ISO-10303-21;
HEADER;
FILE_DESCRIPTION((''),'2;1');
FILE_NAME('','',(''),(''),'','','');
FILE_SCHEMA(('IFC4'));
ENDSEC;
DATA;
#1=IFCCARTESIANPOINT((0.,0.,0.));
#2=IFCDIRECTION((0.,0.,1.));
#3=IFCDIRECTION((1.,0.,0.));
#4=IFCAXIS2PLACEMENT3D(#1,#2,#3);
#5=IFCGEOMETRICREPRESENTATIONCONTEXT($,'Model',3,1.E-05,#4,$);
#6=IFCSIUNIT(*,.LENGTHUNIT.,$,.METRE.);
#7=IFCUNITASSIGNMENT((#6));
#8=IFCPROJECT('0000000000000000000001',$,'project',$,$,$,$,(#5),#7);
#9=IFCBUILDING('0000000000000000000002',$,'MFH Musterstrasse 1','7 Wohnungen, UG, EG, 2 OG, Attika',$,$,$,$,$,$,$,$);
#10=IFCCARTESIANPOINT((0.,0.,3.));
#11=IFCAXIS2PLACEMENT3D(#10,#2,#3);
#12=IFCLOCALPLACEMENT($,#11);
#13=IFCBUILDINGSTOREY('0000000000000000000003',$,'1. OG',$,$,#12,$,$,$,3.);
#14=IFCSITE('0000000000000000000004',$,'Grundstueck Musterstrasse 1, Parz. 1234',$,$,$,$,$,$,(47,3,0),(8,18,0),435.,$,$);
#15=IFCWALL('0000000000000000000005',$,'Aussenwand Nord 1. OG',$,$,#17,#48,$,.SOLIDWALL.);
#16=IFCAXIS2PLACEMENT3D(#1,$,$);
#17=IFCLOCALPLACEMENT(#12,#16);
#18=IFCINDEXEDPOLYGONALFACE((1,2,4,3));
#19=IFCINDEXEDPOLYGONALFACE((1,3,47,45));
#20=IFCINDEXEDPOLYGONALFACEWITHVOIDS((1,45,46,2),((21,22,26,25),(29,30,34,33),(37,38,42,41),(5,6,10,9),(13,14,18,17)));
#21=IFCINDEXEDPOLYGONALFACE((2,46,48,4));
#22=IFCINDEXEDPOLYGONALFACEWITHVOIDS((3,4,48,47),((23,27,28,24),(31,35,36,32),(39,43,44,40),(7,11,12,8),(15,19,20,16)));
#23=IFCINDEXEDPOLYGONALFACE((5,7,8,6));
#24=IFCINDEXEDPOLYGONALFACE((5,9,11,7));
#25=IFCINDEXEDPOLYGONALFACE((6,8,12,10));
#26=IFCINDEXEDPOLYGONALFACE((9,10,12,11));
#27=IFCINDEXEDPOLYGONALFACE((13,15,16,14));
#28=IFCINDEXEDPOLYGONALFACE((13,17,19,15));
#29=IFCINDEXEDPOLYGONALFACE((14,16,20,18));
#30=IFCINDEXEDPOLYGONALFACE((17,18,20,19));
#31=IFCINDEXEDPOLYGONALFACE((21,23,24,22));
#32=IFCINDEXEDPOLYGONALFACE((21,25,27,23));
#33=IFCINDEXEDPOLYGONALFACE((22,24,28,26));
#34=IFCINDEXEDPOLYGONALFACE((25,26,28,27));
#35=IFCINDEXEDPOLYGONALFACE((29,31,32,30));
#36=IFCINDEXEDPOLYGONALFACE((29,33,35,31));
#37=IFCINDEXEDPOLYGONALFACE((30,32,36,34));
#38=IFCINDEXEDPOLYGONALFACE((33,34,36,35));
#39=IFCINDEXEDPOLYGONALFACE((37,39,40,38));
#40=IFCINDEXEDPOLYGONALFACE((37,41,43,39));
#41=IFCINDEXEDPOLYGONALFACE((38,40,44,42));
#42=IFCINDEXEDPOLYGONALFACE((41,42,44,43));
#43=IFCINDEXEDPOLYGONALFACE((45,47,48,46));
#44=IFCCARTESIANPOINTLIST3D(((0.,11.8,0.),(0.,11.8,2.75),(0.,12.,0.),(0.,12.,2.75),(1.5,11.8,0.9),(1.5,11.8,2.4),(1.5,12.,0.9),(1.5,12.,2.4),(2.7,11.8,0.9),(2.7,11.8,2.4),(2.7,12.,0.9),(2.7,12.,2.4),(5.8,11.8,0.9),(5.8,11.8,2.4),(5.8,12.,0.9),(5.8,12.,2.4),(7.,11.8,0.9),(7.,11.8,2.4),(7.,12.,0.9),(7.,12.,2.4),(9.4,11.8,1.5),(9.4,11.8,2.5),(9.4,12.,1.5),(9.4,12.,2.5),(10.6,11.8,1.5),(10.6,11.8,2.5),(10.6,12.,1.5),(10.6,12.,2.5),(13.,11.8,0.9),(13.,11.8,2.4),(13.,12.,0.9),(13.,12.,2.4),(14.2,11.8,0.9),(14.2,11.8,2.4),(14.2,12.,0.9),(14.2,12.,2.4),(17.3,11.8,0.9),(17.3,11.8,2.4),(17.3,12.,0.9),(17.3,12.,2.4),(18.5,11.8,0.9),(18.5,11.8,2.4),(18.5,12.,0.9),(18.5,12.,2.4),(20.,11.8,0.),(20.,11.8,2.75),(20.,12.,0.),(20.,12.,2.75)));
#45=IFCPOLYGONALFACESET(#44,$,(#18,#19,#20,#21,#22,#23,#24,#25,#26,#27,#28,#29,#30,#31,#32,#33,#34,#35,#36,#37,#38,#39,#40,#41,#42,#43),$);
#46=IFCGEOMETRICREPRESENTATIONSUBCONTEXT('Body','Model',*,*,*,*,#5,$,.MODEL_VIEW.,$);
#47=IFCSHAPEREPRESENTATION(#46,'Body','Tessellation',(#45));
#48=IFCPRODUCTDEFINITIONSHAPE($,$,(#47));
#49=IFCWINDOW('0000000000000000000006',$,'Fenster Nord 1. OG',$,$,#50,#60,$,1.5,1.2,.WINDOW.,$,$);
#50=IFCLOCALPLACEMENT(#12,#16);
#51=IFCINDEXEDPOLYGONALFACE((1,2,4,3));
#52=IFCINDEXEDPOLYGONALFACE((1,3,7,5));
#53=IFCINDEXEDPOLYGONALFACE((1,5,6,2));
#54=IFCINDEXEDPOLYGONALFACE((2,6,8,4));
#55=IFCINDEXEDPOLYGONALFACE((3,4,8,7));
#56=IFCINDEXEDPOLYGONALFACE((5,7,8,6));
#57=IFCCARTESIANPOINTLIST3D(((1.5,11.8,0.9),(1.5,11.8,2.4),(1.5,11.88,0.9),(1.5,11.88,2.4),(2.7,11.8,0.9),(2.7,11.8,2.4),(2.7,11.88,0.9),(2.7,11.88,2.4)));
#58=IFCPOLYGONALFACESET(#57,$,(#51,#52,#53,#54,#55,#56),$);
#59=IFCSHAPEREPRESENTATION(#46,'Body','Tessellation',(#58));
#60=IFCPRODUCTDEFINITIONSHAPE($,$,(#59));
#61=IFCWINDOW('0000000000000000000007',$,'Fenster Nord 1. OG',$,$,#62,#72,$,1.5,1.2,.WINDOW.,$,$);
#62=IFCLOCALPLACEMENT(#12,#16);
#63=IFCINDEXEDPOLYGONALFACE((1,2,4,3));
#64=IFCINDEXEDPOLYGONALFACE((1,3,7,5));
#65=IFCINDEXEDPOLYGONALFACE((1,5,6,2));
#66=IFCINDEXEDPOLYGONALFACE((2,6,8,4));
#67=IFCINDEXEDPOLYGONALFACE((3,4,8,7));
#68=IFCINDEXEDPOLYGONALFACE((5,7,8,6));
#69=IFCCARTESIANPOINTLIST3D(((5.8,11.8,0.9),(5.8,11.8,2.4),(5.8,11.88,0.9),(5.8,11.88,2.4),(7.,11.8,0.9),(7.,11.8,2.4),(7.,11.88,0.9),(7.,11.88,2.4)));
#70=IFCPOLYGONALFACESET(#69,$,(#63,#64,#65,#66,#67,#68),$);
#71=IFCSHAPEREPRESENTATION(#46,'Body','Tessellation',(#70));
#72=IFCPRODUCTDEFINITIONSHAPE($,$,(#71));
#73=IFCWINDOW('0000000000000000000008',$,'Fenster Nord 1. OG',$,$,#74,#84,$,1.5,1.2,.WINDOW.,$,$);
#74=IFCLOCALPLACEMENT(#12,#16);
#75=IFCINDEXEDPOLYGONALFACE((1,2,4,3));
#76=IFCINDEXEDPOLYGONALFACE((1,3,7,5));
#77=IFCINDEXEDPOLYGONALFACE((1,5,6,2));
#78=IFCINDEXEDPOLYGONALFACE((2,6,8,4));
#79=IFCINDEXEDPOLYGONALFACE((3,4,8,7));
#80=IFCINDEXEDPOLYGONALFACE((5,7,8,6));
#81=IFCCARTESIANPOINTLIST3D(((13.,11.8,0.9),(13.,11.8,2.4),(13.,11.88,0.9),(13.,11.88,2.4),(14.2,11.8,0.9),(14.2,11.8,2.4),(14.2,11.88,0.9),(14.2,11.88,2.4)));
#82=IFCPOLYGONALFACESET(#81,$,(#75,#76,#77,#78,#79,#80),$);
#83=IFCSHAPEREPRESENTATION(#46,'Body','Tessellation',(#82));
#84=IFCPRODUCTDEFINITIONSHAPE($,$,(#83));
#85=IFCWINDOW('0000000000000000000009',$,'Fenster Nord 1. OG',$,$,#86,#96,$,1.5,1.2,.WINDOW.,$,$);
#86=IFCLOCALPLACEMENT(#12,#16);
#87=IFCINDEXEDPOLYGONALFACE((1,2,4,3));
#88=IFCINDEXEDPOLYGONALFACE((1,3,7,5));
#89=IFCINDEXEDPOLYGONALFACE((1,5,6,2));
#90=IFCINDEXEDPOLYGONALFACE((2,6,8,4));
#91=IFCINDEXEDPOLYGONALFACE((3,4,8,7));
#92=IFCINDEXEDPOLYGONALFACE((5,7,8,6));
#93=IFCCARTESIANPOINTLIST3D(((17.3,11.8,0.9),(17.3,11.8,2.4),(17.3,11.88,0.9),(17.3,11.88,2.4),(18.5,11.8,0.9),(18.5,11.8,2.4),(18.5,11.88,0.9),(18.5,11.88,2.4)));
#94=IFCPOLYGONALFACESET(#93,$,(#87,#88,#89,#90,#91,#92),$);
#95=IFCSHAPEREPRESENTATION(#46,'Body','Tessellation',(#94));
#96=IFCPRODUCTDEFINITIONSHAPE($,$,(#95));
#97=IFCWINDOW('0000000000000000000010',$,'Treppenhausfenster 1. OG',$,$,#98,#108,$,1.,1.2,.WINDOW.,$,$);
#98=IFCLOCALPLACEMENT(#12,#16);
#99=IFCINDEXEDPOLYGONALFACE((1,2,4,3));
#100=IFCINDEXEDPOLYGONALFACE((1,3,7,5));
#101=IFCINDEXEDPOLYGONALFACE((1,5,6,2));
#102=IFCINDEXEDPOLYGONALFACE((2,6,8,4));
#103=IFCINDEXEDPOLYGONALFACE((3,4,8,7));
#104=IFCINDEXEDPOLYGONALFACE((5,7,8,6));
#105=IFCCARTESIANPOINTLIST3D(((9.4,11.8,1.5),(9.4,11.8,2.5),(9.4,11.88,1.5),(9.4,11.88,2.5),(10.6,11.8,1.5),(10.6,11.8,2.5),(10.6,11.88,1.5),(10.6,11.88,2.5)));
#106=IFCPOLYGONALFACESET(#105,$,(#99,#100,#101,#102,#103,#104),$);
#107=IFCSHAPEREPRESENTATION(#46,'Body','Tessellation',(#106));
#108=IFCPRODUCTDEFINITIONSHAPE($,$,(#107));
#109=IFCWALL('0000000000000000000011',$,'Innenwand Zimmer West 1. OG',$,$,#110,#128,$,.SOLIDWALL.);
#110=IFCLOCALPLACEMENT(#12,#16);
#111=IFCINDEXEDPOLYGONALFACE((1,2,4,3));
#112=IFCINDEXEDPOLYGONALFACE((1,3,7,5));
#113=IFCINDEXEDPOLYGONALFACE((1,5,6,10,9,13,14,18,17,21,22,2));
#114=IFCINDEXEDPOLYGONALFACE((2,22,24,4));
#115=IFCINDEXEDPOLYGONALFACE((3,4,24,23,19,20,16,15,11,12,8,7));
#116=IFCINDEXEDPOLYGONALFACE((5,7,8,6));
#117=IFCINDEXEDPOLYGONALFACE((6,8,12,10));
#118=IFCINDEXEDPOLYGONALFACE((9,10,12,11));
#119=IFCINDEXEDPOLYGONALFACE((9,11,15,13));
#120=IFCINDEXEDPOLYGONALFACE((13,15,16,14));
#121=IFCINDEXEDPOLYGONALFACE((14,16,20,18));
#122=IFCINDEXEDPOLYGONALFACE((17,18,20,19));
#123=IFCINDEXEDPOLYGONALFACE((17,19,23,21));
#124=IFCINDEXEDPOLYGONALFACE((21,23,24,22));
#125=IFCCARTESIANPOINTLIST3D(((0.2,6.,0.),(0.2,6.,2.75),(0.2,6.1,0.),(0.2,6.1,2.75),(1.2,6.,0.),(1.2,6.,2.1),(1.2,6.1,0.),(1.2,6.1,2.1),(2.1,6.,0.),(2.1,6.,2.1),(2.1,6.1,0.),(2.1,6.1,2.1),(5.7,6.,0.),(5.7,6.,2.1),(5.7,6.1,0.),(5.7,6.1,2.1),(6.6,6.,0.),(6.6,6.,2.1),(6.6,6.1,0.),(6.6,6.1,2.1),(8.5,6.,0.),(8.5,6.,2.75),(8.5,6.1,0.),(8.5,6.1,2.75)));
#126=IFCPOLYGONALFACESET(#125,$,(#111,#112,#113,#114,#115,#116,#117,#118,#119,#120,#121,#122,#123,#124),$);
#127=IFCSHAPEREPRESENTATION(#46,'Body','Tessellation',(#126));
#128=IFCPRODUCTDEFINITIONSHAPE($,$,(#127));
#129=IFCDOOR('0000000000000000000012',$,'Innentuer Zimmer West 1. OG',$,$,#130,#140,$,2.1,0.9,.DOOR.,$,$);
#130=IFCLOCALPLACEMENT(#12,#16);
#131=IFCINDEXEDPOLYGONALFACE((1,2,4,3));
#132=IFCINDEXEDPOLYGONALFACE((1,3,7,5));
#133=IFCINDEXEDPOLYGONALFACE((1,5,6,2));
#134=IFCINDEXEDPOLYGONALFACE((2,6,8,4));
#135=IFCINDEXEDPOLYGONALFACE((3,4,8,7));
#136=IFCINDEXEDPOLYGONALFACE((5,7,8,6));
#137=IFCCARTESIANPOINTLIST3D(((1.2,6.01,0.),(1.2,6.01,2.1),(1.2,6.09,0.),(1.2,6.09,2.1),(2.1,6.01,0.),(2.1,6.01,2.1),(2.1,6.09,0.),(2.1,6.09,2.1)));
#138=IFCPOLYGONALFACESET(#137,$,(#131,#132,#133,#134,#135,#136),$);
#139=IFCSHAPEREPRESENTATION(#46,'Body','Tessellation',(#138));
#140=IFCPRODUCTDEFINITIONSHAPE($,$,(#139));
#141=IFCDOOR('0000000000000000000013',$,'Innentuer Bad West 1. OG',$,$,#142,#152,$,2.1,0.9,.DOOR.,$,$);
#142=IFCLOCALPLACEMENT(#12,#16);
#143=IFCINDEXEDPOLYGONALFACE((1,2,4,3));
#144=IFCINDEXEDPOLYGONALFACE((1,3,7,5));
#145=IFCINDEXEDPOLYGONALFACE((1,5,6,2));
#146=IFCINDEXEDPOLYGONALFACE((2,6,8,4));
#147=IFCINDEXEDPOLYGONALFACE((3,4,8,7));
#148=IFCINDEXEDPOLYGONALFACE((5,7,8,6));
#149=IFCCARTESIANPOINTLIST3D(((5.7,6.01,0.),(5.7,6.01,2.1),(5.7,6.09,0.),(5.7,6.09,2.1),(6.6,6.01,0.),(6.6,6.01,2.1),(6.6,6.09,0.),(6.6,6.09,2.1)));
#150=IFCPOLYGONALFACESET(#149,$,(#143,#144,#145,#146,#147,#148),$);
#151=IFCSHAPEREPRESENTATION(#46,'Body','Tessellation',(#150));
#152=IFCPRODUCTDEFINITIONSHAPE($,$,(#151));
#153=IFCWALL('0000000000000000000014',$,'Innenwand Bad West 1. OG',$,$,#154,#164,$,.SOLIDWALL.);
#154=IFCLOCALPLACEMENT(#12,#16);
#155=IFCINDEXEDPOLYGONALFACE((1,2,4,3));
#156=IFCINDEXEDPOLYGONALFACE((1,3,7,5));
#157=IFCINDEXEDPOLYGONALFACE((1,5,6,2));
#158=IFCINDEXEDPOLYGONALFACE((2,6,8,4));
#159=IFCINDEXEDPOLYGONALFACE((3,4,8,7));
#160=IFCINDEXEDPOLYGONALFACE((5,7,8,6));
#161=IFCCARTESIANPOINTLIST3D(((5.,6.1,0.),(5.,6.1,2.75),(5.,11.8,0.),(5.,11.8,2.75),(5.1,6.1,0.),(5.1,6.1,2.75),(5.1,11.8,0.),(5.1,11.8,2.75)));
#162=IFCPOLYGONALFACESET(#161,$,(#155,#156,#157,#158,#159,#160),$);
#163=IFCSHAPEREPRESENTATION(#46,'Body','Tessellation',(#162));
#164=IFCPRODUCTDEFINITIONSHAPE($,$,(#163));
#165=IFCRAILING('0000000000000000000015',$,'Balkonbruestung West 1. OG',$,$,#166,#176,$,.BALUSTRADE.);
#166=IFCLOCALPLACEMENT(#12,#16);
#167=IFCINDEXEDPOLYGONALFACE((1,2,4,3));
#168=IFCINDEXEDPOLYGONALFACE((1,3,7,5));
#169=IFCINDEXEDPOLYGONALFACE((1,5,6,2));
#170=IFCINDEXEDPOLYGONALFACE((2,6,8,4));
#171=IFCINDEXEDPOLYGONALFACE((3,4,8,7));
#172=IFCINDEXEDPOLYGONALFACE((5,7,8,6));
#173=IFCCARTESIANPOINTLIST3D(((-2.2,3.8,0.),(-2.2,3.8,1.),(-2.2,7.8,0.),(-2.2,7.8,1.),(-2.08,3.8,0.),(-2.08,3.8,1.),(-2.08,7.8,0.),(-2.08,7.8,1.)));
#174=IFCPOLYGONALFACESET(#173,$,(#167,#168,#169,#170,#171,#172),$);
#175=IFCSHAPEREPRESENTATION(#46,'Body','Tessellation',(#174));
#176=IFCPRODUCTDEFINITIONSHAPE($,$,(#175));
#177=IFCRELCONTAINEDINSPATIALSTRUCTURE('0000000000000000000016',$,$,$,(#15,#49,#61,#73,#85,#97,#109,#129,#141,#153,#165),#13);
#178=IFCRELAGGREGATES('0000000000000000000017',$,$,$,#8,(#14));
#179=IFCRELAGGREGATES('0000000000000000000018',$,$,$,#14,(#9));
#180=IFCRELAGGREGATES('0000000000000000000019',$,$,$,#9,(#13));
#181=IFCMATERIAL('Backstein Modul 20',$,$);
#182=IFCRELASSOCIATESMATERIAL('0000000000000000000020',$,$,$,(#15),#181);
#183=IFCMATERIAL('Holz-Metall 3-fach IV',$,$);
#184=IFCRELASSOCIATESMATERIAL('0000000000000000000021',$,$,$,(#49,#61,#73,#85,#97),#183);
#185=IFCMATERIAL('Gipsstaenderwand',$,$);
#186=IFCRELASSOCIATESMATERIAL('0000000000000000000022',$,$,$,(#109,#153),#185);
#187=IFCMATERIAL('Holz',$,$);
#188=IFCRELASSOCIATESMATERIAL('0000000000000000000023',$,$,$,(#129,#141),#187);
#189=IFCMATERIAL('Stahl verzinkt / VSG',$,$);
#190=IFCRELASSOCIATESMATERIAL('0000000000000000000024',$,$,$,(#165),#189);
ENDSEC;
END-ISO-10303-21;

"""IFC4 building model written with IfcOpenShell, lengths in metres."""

from ifc_helpers import new_model, si_unit, frame, frame_2d, origin_with_axes, place, context, subcontext, project, spatial, rectangle, extrude, material, element, fill, save


model = new_model("IFC4")

# Units and contexts
model_context = context("Model", 3, precision=1e-05, world=origin_with_axes())
body_context = subcontext(model_context, "Body", "Model", "MODEL_VIEW")
ifc_project = project(units=[si_unit("LENGTHUNIT", "METRE")], contexts=[model_context])

# Site, building, storey
site = spatial("IfcSite", under=ifc_project, Name="Grundstueck Musterstrasse 1, Parz. 1234", RefLatitude=(47, 3, 0), RefLongitude=(8, 18, 0), RefElevation=435.0)
building = spatial("IfcBuilding", under=site, Name="MFH Musterstrasse 1", Description="7 Wohnungen, UG, EG, 2 OG, Attika")
storey_placement = place(None, frame((0.0, 0.0, 3.0), z_axis=(0.0, 0.0, 1.0), x_axis=(1.0, 0.0, 0.0)))
storey = spatial("IfcBuildingStorey", under=building, at=storey_placement, Name="1. OG", Elevation=3.0)

# Wall, openings, windows
ifc_material_1 = material(Name="Backstein Modul 20")
wall_1_placement = place(storey_placement, frame((0.0, 11.8, 0.0), z_axis=(0.0, 0.0, 1.0), x_axis=(1.0, 0.0, 0.0)))
wall_1 = element("IfcWall", 1, at=wall_1_placement, inside=storey, material=ifc_material_1, Name="Aussenwand Nord 1. OG", PredefinedType="SOLIDWALL", context=body_context, shape_type="SweptSolid", body=[
    extrude(rectangle(XDim=20.0, YDim=0.2, at=frame_2d((10.0, 0.1))), origin_with_axes(), (0.0, 0.0, 1.0), 2.75),
])
opening_1_placement = place(wall_1_placement, frame((1.5, -0.01, 0.9), z_axis=(0.0, 0.0, 1.0), x_axis=(1.0, 0.0, 0.0)))
opening_1 = element("IfcOpeningElement", 2, at=opening_1_placement, cuts=wall_1, context=body_context, shape_type="SweptSolid", body=[
    extrude(rectangle(XDim=1.2, YDim=0.42, at=frame_2d((0.6, 0.21))), origin_with_axes(), (0.0, 0.0, 1.0), 1.5),
])
opening_2_placement = place(wall_1_placement, frame((5.8, -0.01, 0.9), z_axis=(0.0, 0.0, 1.0), x_axis=(1.0, 0.0, 0.0)))
opening_2 = element("IfcOpeningElement", 3, at=opening_2_placement, cuts=wall_1, context=body_context, shape_type="SweptSolid", body=[
    extrude(rectangle(XDim=1.2, YDim=0.42, at=frame_2d((0.6, 0.21))), origin_with_axes(), (0.0, 0.0, 1.0), 1.5),
])
opening_3_placement = place(wall_1_placement, frame((13.0, -0.01, 0.9), z_axis=(0.0, 0.0, 1.0), x_axis=(1.0, 0.0, 0.0)))
opening_3 = element("IfcOpeningElement", 4, at=opening_3_placement, cuts=wall_1, context=body_context, shape_type="SweptSolid", body=[
    extrude(rectangle(XDim=1.2, YDim=0.42, at=frame_2d((0.6, 0.21))), origin_with_axes(), (0.0, 0.0, 1.0), 1.5),
])
opening_4_placement = place(wall_1_placement, frame((17.3, -0.01, 0.9), z_axis=(0.0, 0.0, 1.0), x_axis=(1.0, 0.0, 0.0)))
opening_4 = element("IfcOpeningElement", 5, at=opening_4_placement, cuts=wall_1, context=body_context, shape_type="SweptSolid", body=[
    extrude(rectangle(XDim=1.2, YDim=0.42, at=frame_2d((0.6, 0.21))), origin_with_axes(), (0.0, 0.0, 1.0), 1.5),
])
opening_5_placement = place(wall_1_placement, frame((9.4, -0.01, 1.5), z_axis=(0.0, 0.0, 1.0), x_axis=(1.0, 0.0, 0.0)))
opening_5 = element("IfcOpeningElement", 6, at=opening_5_placement, cuts=wall_1, context=body_context, shape_type="SweptSolid", body=[
    extrude(rectangle(XDim=1.2, YDim=0.42, at=frame_2d((0.6, 0.21))), origin_with_axes(), (0.0, 0.0, 1.0), 1.0),
])
ifc_material_2 = material(Name="Holz-Metall 3-fach IV")
window_1_placement = place(storey_placement, frame((1.5, 11.8, 0.9), z_axis=(0.0, 0.0, 1.0), x_axis=(1.0, 0.0, 0.0)))
window_1 = element("IfcWindow", 7, at=window_1_placement, inside=storey, material=ifc_material_2, Name="Fenster Nord 1. OG", OverallHeight=1.5, OverallWidth=1.2, PredefinedType="WINDOW", context=body_context, shape_type="SweptSolid", body=[
    extrude(rectangle(XDim=1.2, YDim=0.08, at=frame_2d((0.6, 0.04))), origin_with_axes(), (0.0, 0.0, 1.0), 1.5),
])
fill(opening_1, window_1)
window_2_placement = place(storey_placement, frame((5.8, 11.8, 0.9), z_axis=(0.0, 0.0, 1.0), x_axis=(1.0, 0.0, 0.0)))
window_2 = element("IfcWindow", 8, at=window_2_placement, inside=storey, material=ifc_material_2, Name="Fenster Nord 1. OG", OverallHeight=1.5, OverallWidth=1.2, PredefinedType="WINDOW", context=body_context, shape_type="SweptSolid", body=[
    extrude(rectangle(XDim=1.2, YDim=0.08, at=frame_2d((0.6, 0.04))), origin_with_axes(), (0.0, 0.0, 1.0), 1.5),
])
fill(opening_2, window_2)
window_3_placement = place(storey_placement, frame((13.0, 11.8, 0.9), z_axis=(0.0, 0.0, 1.0), x_axis=(1.0, 0.0, 0.0)))
window_3 = element("IfcWindow", 9, at=window_3_placement, inside=storey, material=ifc_material_2, Name="Fenster Nord 1. OG", OverallHeight=1.5, OverallWidth=1.2, PredefinedType="WINDOW", context=body_context, shape_type="SweptSolid", body=[
    extrude(rectangle(XDim=1.2, YDim=0.08, at=frame_2d((0.6, 0.04))), origin_with_axes(), (0.0, 0.0, 1.0), 1.5),
])
fill(opening_3, window_3)
window_4_placement = place(storey_placement, frame((17.3, 11.8, 0.9), z_axis=(0.0, 0.0, 1.0), x_axis=(1.0, 0.0, 0.0)))
window_4 = element("IfcWindow", 10, at=window_4_placement, inside=storey, material=ifc_material_2, Name="Fenster Nord 1. OG", OverallHeight=1.5, OverallWidth=1.2, PredefinedType="WINDOW", context=body_context, shape_type="SweptSolid", body=[
    extrude(rectangle(XDim=1.2, YDim=0.08, at=frame_2d((0.6, 0.04))), origin_with_axes(), (0.0, 0.0, 1.0), 1.5),
])
fill(opening_4, window_4)
window_5_placement = place(storey_placement, frame((9.4, 11.8, 1.5), z_axis=(0.0, 0.0, 1.0), x_axis=(1.0, 0.0, 0.0)))
window_5 = element("IfcWindow", 11, at=window_5_placement, inside=storey, material=ifc_material_2, Name="Treppenhausfenster 1. OG", OverallHeight=1.0, OverallWidth=1.2, PredefinedType="WINDOW", context=body_context, shape_type="SweptSolid", body=[
    extrude(rectangle(XDim=1.2, YDim=0.08, at=frame_2d((0.6, 0.04))), origin_with_axes(), (0.0, 0.0, 1.0), 1.0),
])
fill(opening_5, window_5)

# Wall, openings, doors
ifc_material_3 = material(Name="Gipsstaenderwand")
wall_2_placement = place(storey_placement, frame((0.2, 6.0, 0.0), z_axis=(0.0, 0.0, 1.0), x_axis=(1.0, 0.0, 0.0)))
wall_2 = element("IfcWall", 12, at=wall_2_placement, inside=storey, material=ifc_material_3, Name="Innenwand Zimmer West 1. OG", PredefinedType="SOLIDWALL", context=body_context, shape_type="SweptSolid", body=[
    extrude(rectangle(XDim=8.3, YDim=0.1, at=frame_2d((4.15, 0.05))), origin_with_axes(), (0.0, 0.0, 1.0), 2.75),
])
opening_6_placement = place(wall_2_placement, frame((1.0, -0.01, 0.0), z_axis=(0.0, 0.0, 1.0), x_axis=(1.0, 0.0, 0.0)))
opening_6 = element("IfcOpeningElement", 13, at=opening_6_placement, cuts=wall_2, context=body_context, shape_type="SweptSolid", body=[
    extrude(rectangle(XDim=0.9, YDim=0.12, at=frame_2d((0.45, 0.06))), origin_with_axes(), (0.0, 0.0, 1.0), 2.1),
])
opening_7_placement = place(wall_2_placement, frame((5.5, -0.01, 0.0), z_axis=(0.0, 0.0, 1.0), x_axis=(1.0, 0.0, 0.0)))
opening_7 = element("IfcOpeningElement", 14, at=opening_7_placement, cuts=wall_2, context=body_context, shape_type="SweptSolid", body=[
    extrude(rectangle(XDim=0.9, YDim=0.12, at=frame_2d((0.45, 0.06))), origin_with_axes(), (0.0, 0.0, 1.0), 2.1),
])
ifc_material_4 = material(Name="Holz")
door_1_placement = place(storey_placement, frame((1.2, 6.01, 0.0), z_axis=(0.0, 0.0, 1.0), x_axis=(1.0, 0.0, 0.0)))
door_1 = element("IfcDoor", 15, at=door_1_placement, inside=storey, material=ifc_material_4, Name="Innentuer Zimmer West 1. OG", OverallHeight=2.1, OverallWidth=0.9, PredefinedType="DOOR", context=body_context, shape_type="SweptSolid", body=[
    extrude(rectangle(XDim=0.9, YDim=0.08, at=frame_2d((0.45, 0.04))), origin_with_axes(), (0.0, 0.0, 1.0), 2.1),
])
fill(opening_6, door_1)
door_2_placement = place(storey_placement, frame((5.7, 6.01, 0.0), z_axis=(0.0, 0.0, 1.0), x_axis=(1.0, 0.0, 0.0)))
door_2 = element("IfcDoor", 16, at=door_2_placement, inside=storey, material=ifc_material_4, Name="Innentuer Bad West 1. OG", OverallHeight=2.1, OverallWidth=0.9, PredefinedType="DOOR", context=body_context, shape_type="SweptSolid", body=[
    extrude(rectangle(XDim=0.9, YDim=0.08, at=frame_2d((0.45, 0.04))), origin_with_axes(), (0.0, 0.0, 1.0), 2.1),
])
fill(opening_7, door_2)

# Wall
wall_3_placement = place(storey_placement, frame((5.0, 6.1, 0.0), z_axis=(0.0, 0.0, 1.0), x_axis=(1.0, 0.0, 0.0)))
element("IfcWall", 17, at=wall_3_placement, inside=storey, material=ifc_material_3, Name="Innenwand Bad West 1. OG", PredefinedType="SOLIDWALL", context=body_context, shape_type="SweptSolid", body=[
    extrude(rectangle(XDim=0.1, YDim=5.7, at=frame_2d((0.05, 2.85))), origin_with_axes(), (0.0, 0.0, 1.0), 2.75),
])

# Railing
ifc_material_5 = material(Name="Stahl verzinkt / VSG")
railing_placement = place(storey_placement, frame((-2.2, 3.8, 0.0), z_axis=(0.0, 0.0, 1.0), x_axis=(1.0, 0.0, 0.0)))
element("IfcRailing", 18, at=railing_placement, inside=storey, material=ifc_material_5, Name="Balkonbruestung West 1. OG", PredefinedType="BALUSTRADE", context=body_context, shape_type="SweptSolid", body=[
    extrude(rectangle(XDim=0.12, YDim=4.0, at=frame_2d((0.06, 2.0))), origin_with_axes(), (0.0, 0.0, 1.0), 1.0),
])

save(model, "model.ifc")
